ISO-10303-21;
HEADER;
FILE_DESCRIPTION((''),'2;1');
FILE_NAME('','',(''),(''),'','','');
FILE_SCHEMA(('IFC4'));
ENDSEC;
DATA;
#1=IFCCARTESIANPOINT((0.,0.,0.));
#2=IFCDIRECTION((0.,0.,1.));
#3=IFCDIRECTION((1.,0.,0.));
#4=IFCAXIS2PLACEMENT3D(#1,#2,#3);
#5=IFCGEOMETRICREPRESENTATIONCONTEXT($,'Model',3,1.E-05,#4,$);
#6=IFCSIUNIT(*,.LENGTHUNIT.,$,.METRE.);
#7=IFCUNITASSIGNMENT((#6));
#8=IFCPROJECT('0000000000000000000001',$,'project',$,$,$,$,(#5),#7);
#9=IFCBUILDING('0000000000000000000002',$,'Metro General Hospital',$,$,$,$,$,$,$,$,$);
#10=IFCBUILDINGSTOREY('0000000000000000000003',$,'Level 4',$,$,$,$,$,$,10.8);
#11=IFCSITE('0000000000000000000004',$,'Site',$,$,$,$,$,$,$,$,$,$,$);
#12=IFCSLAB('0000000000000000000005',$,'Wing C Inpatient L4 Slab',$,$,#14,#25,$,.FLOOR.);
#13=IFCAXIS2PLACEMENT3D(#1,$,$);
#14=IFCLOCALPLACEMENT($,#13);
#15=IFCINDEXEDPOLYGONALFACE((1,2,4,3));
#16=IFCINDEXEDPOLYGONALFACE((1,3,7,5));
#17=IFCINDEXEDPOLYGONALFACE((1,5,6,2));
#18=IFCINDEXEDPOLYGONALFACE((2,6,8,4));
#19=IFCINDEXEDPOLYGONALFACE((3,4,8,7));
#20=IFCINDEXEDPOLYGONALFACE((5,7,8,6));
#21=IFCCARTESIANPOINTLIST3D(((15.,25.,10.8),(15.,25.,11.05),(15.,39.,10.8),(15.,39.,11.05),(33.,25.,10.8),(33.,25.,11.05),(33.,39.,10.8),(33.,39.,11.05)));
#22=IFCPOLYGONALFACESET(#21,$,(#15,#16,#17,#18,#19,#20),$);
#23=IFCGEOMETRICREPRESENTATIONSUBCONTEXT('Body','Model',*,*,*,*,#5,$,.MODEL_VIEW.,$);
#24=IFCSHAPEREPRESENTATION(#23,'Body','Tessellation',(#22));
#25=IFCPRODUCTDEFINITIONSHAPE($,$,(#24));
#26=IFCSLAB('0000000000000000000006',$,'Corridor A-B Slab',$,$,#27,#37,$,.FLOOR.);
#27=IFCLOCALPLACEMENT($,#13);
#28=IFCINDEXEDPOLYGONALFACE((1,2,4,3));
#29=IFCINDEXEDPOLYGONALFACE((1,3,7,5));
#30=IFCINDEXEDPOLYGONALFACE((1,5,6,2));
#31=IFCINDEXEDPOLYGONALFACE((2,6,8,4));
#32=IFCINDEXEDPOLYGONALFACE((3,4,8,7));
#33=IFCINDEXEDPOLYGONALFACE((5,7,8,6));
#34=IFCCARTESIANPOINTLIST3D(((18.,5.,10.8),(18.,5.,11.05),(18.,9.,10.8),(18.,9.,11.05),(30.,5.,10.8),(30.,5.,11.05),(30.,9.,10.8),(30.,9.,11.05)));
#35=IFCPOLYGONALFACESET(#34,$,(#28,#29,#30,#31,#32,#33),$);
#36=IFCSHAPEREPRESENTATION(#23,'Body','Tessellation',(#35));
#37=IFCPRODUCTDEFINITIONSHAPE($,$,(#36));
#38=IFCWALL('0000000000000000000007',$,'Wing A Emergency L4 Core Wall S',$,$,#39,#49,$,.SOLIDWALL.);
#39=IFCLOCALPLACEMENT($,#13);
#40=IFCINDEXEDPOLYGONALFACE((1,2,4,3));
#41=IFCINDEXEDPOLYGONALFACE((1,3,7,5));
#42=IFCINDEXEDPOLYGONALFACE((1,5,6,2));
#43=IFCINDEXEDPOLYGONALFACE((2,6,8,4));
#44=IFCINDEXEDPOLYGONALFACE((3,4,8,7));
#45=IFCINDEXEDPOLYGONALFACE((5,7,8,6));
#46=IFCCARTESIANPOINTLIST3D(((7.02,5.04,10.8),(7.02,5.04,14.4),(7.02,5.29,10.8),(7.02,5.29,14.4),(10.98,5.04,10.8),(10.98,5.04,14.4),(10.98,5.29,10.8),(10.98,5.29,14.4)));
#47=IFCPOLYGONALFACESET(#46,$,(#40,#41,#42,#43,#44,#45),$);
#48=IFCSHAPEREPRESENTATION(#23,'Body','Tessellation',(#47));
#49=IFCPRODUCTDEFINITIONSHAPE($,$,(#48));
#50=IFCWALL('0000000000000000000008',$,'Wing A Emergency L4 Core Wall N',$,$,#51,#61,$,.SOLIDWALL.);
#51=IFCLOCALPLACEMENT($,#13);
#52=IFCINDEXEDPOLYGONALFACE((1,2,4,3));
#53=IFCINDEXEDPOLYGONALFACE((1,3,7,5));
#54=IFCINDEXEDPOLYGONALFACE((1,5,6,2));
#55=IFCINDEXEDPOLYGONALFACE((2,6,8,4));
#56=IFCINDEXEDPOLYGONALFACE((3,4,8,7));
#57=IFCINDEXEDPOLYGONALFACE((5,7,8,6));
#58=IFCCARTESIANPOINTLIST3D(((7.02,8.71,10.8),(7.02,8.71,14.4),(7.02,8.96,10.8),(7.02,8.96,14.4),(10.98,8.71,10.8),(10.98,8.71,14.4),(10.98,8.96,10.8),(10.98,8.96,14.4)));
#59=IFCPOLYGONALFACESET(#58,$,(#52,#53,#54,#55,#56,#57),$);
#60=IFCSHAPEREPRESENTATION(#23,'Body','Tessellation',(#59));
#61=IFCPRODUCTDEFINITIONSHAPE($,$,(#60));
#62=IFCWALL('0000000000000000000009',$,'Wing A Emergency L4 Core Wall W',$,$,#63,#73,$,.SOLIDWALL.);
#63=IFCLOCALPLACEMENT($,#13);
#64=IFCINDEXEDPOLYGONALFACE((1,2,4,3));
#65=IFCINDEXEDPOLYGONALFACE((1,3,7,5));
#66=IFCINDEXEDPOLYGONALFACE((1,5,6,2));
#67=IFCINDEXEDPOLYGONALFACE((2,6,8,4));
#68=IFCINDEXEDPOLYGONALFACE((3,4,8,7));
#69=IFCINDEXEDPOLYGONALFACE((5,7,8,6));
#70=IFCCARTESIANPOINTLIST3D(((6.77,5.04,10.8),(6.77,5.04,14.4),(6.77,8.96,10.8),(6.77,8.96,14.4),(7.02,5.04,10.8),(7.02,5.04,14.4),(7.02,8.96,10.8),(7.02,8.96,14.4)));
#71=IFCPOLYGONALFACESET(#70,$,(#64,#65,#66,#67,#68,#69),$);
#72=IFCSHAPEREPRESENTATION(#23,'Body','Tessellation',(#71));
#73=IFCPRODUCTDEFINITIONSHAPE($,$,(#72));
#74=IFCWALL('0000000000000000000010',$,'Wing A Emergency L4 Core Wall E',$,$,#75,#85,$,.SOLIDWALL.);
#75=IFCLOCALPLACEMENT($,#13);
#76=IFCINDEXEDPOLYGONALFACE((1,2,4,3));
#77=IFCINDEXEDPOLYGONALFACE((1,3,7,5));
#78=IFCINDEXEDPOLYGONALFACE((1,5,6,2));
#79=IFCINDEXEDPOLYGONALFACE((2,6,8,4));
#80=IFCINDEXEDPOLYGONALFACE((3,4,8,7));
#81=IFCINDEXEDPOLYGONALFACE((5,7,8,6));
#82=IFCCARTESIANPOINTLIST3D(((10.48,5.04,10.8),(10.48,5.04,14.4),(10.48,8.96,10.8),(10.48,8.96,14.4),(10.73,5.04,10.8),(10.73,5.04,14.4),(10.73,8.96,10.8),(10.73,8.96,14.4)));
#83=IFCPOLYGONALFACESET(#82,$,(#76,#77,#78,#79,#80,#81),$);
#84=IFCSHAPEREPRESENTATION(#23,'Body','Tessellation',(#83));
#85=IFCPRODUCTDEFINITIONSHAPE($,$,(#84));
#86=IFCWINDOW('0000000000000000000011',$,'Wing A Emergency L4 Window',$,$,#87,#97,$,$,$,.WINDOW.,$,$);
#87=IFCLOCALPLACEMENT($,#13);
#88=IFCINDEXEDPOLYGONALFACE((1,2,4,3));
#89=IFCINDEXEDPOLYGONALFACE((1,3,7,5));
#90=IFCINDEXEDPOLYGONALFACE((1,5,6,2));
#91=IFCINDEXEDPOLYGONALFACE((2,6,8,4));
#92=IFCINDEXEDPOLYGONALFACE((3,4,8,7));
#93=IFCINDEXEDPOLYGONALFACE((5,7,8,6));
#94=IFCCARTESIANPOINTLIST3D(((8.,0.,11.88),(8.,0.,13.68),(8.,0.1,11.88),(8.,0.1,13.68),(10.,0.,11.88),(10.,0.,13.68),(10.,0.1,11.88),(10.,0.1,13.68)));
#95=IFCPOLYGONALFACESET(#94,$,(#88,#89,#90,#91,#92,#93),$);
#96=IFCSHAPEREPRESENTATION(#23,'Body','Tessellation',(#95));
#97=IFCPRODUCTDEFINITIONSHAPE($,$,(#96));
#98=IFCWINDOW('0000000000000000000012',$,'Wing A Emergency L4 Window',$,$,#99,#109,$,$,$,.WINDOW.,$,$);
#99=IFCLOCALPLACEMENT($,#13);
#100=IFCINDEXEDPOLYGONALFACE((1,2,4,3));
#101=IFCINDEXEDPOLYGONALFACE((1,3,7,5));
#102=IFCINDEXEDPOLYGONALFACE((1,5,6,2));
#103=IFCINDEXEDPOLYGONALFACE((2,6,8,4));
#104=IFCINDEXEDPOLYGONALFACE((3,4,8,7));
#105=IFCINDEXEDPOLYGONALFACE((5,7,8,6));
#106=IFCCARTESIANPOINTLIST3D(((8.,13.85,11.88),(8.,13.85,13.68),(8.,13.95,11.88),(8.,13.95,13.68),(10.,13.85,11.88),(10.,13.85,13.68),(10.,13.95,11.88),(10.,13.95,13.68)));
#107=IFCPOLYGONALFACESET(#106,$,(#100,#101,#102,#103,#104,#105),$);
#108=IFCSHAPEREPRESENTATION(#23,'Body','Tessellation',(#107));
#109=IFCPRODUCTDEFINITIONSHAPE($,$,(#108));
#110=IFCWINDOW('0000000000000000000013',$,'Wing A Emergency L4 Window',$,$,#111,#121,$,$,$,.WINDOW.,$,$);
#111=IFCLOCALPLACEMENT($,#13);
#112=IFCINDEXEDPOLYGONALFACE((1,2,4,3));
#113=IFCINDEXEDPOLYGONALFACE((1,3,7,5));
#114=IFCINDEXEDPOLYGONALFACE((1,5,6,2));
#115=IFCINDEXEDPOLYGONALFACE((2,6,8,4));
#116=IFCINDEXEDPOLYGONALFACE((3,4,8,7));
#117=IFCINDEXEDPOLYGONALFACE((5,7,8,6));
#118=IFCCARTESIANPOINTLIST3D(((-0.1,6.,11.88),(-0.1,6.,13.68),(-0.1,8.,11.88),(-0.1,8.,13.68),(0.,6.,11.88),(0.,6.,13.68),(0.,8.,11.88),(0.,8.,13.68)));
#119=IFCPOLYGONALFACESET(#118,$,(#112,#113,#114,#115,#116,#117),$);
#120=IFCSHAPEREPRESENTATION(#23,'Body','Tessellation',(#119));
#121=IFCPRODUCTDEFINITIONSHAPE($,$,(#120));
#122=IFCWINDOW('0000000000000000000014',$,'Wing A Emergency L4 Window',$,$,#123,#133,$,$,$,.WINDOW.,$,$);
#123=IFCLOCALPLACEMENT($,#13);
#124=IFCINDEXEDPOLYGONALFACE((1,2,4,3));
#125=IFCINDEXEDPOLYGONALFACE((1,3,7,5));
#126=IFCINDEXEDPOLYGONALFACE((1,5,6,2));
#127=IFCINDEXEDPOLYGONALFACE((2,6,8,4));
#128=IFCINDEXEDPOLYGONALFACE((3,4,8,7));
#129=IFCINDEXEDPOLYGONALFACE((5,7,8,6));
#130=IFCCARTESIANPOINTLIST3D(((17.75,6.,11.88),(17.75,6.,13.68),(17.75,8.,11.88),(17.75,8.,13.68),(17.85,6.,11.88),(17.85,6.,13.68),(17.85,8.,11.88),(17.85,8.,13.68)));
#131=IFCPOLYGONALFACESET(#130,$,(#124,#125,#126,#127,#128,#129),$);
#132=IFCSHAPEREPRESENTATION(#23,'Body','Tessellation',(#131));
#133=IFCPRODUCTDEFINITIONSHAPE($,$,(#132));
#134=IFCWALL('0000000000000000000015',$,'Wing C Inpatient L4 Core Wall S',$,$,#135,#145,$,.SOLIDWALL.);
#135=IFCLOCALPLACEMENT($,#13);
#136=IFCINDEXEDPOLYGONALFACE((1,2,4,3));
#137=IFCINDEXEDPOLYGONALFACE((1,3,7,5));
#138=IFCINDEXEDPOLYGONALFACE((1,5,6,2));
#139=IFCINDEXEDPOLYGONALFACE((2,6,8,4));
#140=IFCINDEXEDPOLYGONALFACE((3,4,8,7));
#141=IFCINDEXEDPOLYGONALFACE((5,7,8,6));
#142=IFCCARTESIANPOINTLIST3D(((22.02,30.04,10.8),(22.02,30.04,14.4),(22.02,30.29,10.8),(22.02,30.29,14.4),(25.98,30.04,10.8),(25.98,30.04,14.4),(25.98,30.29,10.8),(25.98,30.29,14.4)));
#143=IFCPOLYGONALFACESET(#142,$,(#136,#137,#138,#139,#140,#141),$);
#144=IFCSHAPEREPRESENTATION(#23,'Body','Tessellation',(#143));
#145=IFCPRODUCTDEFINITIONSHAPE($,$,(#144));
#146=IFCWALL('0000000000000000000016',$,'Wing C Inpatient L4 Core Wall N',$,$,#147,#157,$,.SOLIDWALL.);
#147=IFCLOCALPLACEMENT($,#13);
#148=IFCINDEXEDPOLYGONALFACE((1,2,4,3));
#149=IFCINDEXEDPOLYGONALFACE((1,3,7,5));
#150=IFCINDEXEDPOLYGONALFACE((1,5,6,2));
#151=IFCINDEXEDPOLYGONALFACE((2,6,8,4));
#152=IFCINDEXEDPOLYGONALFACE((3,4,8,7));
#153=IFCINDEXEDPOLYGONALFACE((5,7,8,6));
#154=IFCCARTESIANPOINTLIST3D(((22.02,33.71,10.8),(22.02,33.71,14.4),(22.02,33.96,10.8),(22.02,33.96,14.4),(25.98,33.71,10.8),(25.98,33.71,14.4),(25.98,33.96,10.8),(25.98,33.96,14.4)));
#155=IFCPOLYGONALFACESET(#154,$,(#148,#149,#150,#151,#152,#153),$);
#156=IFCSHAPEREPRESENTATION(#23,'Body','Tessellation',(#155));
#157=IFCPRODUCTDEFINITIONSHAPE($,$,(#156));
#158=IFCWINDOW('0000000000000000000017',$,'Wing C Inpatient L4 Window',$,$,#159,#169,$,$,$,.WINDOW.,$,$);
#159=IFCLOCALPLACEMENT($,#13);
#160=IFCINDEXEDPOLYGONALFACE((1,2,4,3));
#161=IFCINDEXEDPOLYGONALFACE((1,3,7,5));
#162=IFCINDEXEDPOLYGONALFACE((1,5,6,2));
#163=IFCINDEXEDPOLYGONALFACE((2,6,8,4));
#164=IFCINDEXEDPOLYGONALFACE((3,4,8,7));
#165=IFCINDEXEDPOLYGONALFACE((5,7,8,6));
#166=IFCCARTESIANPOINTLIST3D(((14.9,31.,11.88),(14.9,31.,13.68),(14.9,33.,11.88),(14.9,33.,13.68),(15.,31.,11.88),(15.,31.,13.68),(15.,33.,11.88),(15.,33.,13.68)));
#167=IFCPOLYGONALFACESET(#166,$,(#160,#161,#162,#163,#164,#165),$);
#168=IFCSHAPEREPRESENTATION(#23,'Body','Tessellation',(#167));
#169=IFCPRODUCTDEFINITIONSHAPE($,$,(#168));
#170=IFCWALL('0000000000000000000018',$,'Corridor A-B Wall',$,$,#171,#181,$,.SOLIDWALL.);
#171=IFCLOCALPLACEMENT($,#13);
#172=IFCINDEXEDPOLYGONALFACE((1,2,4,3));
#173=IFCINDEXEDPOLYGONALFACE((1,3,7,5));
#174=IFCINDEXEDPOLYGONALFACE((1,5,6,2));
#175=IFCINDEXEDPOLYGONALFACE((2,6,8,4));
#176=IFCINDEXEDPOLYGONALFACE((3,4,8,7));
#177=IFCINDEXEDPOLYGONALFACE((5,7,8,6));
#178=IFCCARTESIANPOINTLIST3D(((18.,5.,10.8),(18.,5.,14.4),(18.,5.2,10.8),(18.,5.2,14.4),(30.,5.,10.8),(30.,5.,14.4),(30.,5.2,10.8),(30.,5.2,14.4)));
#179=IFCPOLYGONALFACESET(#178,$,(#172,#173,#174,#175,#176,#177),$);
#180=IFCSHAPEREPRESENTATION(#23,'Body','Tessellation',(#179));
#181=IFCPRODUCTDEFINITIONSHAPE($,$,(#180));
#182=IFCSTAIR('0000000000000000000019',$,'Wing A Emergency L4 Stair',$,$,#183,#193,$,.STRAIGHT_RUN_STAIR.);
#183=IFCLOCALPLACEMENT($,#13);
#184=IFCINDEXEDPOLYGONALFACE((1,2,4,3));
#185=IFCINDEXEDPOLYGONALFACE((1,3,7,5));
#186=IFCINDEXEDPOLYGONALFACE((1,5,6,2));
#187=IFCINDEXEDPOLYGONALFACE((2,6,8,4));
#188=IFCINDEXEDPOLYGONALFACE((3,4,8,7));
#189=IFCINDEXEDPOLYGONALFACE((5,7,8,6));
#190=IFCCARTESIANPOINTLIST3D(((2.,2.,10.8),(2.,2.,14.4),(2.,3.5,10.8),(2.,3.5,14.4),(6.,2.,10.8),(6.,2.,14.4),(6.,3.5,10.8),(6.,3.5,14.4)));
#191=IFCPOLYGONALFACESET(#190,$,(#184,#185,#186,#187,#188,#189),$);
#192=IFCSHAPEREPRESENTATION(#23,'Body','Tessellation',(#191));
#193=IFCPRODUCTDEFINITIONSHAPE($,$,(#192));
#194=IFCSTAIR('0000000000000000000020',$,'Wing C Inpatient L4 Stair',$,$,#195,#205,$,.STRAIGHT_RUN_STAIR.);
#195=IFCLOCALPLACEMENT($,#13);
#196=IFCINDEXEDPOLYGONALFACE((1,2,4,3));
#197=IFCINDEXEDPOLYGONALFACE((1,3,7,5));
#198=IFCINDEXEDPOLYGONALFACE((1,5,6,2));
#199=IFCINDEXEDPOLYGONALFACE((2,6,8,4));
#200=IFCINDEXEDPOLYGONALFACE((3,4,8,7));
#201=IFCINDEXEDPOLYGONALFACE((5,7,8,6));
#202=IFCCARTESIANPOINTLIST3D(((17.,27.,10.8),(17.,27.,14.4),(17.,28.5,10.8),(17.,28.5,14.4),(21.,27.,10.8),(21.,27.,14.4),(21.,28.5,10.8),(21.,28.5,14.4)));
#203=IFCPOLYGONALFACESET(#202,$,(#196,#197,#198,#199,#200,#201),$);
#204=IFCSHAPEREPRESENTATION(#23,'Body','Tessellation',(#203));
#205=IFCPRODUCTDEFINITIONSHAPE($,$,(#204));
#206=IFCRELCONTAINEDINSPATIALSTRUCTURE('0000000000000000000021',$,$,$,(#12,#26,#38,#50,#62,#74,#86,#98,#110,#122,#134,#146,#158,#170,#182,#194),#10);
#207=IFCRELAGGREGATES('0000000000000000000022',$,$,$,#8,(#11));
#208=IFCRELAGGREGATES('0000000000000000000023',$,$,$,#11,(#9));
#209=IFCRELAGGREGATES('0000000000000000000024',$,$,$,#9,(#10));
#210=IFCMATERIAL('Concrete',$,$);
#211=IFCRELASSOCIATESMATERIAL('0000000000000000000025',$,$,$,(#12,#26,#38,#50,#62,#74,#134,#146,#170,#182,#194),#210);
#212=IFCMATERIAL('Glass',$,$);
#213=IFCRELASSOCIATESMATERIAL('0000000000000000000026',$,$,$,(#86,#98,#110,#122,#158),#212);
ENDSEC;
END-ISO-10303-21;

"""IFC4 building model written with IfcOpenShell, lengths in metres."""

from ifc_helpers import new_model, si_unit, frame, origin_with_axes, place, context, subcontext, project, spatial, line, indexed_curve, outline, extrude, material, element, save


model = new_model("IFC4")

# Units and contexts
model_context = context("Model", 3, precision=1e-05, world=origin_with_axes())
body_context = subcontext(model_context, "Body", "Model", "MODEL_VIEW")
ifc_project = project(units=[si_unit("LENGTHUNIT", "METRE")], contexts=[model_context])

# Site, building, storey
site = spatial("IfcSite", under=ifc_project, Name="Site")
building = spatial("IfcBuilding", under=site, Name="Metro General Hospital")
storey = spatial("IfcBuildingStorey", under=building, Name="Level 4", Elevation=10.8)

# Slabs
ifc_material_1 = material(Name="Concrete")
for number, where, z_axis, x_axis, name in (
    (1, (15.0, 25.0, 10.8), (0.0, 0.0, 1.0), (1.0, 0.0, 0.0), "Wing C Inpatient L4 Slab"),
):
    element("IfcSlab", number, at=place(None, frame(where, z_axis=z_axis, x_axis=x_axis)), inside=storey, material=ifc_material_1, Name=name, PredefinedType="FLOOR", context=body_context, shape_type="SweptSolid", body=[
        extrude(outline(indexed_curve([(0.0, 0.0), (18.0, 0.0), (18.0, 14.0), (0.0, 14.0)], segments=[line(1, 2, 3, 4, 1)])), origin_with_axes(), (0.0, 0.0, 1.0), 0.25),
    ])
slab_placement = place(None, frame((18.0, 5.0, 10.8), z_axis=(0.0, 0.0, 1.0), x_axis=(1.0, 0.0, 0.0)))
element("IfcSlab", 2, at=slab_placement, inside=storey, material=ifc_material_1, Name="Corridor A-B Slab", PredefinedType="FLOOR", context=body_context, shape_type="SweptSolid", body=[
    extrude(outline(indexed_curve([(0.0, 0.0), (12.0, 0.0), (12.0, 4.0), (0.0, 4.0)], segments=[line(1, 2, 3, 4, 1)])), origin_with_axes(), (0.0, 0.0, 1.0), 0.25),
])

# Walls
for number, where, z_axis, x_axis, name in (
    (3, (7.02, 5.04, 10.8), (0.0, 0.0, 1.0), (1.0, 0.0, 0.0), "Wing A Emergency L4 Core Wall S"),
    (4, (7.02, 8.71, 10.8), (0.0, 0.0, 1.0), (1.0, 0.0, 0.0), "Wing A Emergency L4 Core Wall N"),
):
    element("IfcWall", number, at=place(None, frame(where, z_axis=z_axis, x_axis=x_axis)), inside=storey, material=ifc_material_1, Name=name, PredefinedType="SOLIDWALL", context=body_context, shape_type="SweptSolid", body=[
        extrude(outline(indexed_curve([(0.0, 0.0), (3.96, 0.0), (3.96, 0.25), (0.0, 0.25)], segments=[line(1, 2, 3, 4, 1)])), origin_with_axes(), (0.0, 0.0, 1.0), 3.6),
    ])
for number, where, z_axis, x_axis, name in (
    (5, (7.02, 5.04, 10.8), (0.0, 0.0, 1.0), (0.0, 1.0, 0.0), "Wing A Emergency L4 Core Wall W"),
    (6, (10.73, 5.04, 10.8), (0.0, 0.0, 1.0), (0.0, 1.0, 0.0), "Wing A Emergency L4 Core Wall E"),
):
    element("IfcWall", number, at=place(None, frame(where, z_axis=z_axis, x_axis=x_axis)), inside=storey, material=ifc_material_1, Name=name, PredefinedType="SOLIDWALL", context=body_context, shape_type="SweptSolid", body=[
        extrude(outline(indexed_curve([(0.0, 0.0), (3.92, 0.0), (3.92, 0.25), (0.0, 0.25)], segments=[line(1, 2, 3, 4, 1)])), origin_with_axes(), (0.0, 0.0, 1.0), 3.6),
    ])

# Windows
ifc_material_2 = material(Name="Glass")
for number, where, z_axis, x_axis, name in (
    (7, (8.0, 0.0, 11.88), (0.0, 0.0, 1.0), (1.0, 0.0, 0.0), "Wing A Emergency L4 Window"),
    (8, (8.0, 13.85, 11.88), (0.0, 0.0, 1.0), (1.0, 0.0, 0.0), "Wing A Emergency L4 Window"),
    (9, (0.0, 6.0, 11.88), (0.0, 0.0, 1.0), (0.0, 1.0, 0.0), "Wing A Emergency L4 Window"),
    (10, (17.85, 6.0, 11.88), (0.0, 0.0, 1.0), (0.0, 1.0, 0.0), "Wing A Emergency L4 Window"),
):
    element("IfcWindow", number, at=place(None, frame(where, z_axis=z_axis, x_axis=x_axis)), inside=storey, material=ifc_material_2, Name=name, PredefinedType="WINDOW", context=body_context, shape_type="SweptSolid", body=[
        extrude(outline(indexed_curve([(0.0, 0.0), (2.0, 0.0), (2.0, 0.1), (0.0, 0.1)], segments=[line(1, 2, 3, 4, 1)])), origin_with_axes(), (0.0, 0.0, 1.0), 1.8),
    ])

# Walls
for number, where, z_axis, x_axis, name in (
    (11, (22.02, 30.04, 10.8), (0.0, 0.0, 1.0), (1.0, 0.0, 0.0), "Wing C Inpatient L4 Core Wall S"),
    (12, (22.02, 33.71, 10.8), (0.0, 0.0, 1.0), (1.0, 0.0, 0.0), "Wing C Inpatient L4 Core Wall N"),
):
    element("IfcWall", number, at=place(None, frame(where, z_axis=z_axis, x_axis=x_axis)), inside=storey, material=ifc_material_1, Name=name, PredefinedType="SOLIDWALL", context=body_context, shape_type="SweptSolid", body=[
        extrude(outline(indexed_curve([(0.0, 0.0), (3.96, 0.0), (3.96, 0.25), (0.0, 0.25)], segments=[line(1, 2, 3, 4, 1)])), origin_with_axes(), (0.0, 0.0, 1.0), 3.6),
    ])

# Window
window_placement = place(None, frame((15.0, 31.0, 11.88), z_axis=(0.0, 0.0, 1.0), x_axis=(0.0, 1.0, 0.0)))
element("IfcWindow", 13, at=window_placement, inside=storey, material=ifc_material_2, Name="Wing C Inpatient L4 Window", PredefinedType="WINDOW", context=body_context, shape_type="SweptSolid", body=[
    extrude(outline(indexed_curve([(0.0, 0.0), (2.0, 0.0), (2.0, 0.1), (0.0, 0.1)], segments=[line(1, 2, 3, 4, 1)])), origin_with_axes(), (0.0, 0.0, 1.0), 1.8),
])

# Wall
wall_placement = place(None, frame((18.0, 5.0, 10.8), z_axis=(0.0, 0.0, 1.0), x_axis=(1.0, 0.0, 0.0)))
element("IfcWall", 14, at=wall_placement, inside=storey, material=ifc_material_1, Name="Corridor A-B Wall", PredefinedType="SOLIDWALL", context=body_context, shape_type="SweptSolid", body=[
    extrude(outline(indexed_curve([(0.0, 0.0), (12.0, 0.0), (12.0, 0.2), (0.0, 0.2)], segments=[line(1, 2, 3, 4, 1)])), origin_with_axes(), (0.0, 0.0, 1.0), 3.6),
])

# Stairs
for number, where, z_axis, x_axis, name in (
    (15, (2.0, 2.0, 10.8), (0.0, 0.0, 1.0), (1.0, 0.0, 0.0), "Wing A Emergency L4 Stair"),
    (16, (17.0, 27.0, 10.8), (0.0, 0.0, 1.0), (1.0, 0.0, 0.0), "Wing C Inpatient L4 Stair"),
):
    element("IfcStair", number, at=place(None, frame(where, z_axis=z_axis, x_axis=x_axis)), inside=storey, material=ifc_material_1, Name=name, PredefinedType="STRAIGHT_RUN_STAIR", context=body_context, shape_type="SweptSolid", body=[
        extrude(outline(indexed_curve([(0.0, 0.0), (4.0, 0.0), (4.0, 1.5), (0.0, 1.5)], segments=[line(1, 2, 3, 4, 1)])), origin_with_axes(), (0.0, 0.0, 1.0), 3.6),
    ])

save(model, "model.ifc")
